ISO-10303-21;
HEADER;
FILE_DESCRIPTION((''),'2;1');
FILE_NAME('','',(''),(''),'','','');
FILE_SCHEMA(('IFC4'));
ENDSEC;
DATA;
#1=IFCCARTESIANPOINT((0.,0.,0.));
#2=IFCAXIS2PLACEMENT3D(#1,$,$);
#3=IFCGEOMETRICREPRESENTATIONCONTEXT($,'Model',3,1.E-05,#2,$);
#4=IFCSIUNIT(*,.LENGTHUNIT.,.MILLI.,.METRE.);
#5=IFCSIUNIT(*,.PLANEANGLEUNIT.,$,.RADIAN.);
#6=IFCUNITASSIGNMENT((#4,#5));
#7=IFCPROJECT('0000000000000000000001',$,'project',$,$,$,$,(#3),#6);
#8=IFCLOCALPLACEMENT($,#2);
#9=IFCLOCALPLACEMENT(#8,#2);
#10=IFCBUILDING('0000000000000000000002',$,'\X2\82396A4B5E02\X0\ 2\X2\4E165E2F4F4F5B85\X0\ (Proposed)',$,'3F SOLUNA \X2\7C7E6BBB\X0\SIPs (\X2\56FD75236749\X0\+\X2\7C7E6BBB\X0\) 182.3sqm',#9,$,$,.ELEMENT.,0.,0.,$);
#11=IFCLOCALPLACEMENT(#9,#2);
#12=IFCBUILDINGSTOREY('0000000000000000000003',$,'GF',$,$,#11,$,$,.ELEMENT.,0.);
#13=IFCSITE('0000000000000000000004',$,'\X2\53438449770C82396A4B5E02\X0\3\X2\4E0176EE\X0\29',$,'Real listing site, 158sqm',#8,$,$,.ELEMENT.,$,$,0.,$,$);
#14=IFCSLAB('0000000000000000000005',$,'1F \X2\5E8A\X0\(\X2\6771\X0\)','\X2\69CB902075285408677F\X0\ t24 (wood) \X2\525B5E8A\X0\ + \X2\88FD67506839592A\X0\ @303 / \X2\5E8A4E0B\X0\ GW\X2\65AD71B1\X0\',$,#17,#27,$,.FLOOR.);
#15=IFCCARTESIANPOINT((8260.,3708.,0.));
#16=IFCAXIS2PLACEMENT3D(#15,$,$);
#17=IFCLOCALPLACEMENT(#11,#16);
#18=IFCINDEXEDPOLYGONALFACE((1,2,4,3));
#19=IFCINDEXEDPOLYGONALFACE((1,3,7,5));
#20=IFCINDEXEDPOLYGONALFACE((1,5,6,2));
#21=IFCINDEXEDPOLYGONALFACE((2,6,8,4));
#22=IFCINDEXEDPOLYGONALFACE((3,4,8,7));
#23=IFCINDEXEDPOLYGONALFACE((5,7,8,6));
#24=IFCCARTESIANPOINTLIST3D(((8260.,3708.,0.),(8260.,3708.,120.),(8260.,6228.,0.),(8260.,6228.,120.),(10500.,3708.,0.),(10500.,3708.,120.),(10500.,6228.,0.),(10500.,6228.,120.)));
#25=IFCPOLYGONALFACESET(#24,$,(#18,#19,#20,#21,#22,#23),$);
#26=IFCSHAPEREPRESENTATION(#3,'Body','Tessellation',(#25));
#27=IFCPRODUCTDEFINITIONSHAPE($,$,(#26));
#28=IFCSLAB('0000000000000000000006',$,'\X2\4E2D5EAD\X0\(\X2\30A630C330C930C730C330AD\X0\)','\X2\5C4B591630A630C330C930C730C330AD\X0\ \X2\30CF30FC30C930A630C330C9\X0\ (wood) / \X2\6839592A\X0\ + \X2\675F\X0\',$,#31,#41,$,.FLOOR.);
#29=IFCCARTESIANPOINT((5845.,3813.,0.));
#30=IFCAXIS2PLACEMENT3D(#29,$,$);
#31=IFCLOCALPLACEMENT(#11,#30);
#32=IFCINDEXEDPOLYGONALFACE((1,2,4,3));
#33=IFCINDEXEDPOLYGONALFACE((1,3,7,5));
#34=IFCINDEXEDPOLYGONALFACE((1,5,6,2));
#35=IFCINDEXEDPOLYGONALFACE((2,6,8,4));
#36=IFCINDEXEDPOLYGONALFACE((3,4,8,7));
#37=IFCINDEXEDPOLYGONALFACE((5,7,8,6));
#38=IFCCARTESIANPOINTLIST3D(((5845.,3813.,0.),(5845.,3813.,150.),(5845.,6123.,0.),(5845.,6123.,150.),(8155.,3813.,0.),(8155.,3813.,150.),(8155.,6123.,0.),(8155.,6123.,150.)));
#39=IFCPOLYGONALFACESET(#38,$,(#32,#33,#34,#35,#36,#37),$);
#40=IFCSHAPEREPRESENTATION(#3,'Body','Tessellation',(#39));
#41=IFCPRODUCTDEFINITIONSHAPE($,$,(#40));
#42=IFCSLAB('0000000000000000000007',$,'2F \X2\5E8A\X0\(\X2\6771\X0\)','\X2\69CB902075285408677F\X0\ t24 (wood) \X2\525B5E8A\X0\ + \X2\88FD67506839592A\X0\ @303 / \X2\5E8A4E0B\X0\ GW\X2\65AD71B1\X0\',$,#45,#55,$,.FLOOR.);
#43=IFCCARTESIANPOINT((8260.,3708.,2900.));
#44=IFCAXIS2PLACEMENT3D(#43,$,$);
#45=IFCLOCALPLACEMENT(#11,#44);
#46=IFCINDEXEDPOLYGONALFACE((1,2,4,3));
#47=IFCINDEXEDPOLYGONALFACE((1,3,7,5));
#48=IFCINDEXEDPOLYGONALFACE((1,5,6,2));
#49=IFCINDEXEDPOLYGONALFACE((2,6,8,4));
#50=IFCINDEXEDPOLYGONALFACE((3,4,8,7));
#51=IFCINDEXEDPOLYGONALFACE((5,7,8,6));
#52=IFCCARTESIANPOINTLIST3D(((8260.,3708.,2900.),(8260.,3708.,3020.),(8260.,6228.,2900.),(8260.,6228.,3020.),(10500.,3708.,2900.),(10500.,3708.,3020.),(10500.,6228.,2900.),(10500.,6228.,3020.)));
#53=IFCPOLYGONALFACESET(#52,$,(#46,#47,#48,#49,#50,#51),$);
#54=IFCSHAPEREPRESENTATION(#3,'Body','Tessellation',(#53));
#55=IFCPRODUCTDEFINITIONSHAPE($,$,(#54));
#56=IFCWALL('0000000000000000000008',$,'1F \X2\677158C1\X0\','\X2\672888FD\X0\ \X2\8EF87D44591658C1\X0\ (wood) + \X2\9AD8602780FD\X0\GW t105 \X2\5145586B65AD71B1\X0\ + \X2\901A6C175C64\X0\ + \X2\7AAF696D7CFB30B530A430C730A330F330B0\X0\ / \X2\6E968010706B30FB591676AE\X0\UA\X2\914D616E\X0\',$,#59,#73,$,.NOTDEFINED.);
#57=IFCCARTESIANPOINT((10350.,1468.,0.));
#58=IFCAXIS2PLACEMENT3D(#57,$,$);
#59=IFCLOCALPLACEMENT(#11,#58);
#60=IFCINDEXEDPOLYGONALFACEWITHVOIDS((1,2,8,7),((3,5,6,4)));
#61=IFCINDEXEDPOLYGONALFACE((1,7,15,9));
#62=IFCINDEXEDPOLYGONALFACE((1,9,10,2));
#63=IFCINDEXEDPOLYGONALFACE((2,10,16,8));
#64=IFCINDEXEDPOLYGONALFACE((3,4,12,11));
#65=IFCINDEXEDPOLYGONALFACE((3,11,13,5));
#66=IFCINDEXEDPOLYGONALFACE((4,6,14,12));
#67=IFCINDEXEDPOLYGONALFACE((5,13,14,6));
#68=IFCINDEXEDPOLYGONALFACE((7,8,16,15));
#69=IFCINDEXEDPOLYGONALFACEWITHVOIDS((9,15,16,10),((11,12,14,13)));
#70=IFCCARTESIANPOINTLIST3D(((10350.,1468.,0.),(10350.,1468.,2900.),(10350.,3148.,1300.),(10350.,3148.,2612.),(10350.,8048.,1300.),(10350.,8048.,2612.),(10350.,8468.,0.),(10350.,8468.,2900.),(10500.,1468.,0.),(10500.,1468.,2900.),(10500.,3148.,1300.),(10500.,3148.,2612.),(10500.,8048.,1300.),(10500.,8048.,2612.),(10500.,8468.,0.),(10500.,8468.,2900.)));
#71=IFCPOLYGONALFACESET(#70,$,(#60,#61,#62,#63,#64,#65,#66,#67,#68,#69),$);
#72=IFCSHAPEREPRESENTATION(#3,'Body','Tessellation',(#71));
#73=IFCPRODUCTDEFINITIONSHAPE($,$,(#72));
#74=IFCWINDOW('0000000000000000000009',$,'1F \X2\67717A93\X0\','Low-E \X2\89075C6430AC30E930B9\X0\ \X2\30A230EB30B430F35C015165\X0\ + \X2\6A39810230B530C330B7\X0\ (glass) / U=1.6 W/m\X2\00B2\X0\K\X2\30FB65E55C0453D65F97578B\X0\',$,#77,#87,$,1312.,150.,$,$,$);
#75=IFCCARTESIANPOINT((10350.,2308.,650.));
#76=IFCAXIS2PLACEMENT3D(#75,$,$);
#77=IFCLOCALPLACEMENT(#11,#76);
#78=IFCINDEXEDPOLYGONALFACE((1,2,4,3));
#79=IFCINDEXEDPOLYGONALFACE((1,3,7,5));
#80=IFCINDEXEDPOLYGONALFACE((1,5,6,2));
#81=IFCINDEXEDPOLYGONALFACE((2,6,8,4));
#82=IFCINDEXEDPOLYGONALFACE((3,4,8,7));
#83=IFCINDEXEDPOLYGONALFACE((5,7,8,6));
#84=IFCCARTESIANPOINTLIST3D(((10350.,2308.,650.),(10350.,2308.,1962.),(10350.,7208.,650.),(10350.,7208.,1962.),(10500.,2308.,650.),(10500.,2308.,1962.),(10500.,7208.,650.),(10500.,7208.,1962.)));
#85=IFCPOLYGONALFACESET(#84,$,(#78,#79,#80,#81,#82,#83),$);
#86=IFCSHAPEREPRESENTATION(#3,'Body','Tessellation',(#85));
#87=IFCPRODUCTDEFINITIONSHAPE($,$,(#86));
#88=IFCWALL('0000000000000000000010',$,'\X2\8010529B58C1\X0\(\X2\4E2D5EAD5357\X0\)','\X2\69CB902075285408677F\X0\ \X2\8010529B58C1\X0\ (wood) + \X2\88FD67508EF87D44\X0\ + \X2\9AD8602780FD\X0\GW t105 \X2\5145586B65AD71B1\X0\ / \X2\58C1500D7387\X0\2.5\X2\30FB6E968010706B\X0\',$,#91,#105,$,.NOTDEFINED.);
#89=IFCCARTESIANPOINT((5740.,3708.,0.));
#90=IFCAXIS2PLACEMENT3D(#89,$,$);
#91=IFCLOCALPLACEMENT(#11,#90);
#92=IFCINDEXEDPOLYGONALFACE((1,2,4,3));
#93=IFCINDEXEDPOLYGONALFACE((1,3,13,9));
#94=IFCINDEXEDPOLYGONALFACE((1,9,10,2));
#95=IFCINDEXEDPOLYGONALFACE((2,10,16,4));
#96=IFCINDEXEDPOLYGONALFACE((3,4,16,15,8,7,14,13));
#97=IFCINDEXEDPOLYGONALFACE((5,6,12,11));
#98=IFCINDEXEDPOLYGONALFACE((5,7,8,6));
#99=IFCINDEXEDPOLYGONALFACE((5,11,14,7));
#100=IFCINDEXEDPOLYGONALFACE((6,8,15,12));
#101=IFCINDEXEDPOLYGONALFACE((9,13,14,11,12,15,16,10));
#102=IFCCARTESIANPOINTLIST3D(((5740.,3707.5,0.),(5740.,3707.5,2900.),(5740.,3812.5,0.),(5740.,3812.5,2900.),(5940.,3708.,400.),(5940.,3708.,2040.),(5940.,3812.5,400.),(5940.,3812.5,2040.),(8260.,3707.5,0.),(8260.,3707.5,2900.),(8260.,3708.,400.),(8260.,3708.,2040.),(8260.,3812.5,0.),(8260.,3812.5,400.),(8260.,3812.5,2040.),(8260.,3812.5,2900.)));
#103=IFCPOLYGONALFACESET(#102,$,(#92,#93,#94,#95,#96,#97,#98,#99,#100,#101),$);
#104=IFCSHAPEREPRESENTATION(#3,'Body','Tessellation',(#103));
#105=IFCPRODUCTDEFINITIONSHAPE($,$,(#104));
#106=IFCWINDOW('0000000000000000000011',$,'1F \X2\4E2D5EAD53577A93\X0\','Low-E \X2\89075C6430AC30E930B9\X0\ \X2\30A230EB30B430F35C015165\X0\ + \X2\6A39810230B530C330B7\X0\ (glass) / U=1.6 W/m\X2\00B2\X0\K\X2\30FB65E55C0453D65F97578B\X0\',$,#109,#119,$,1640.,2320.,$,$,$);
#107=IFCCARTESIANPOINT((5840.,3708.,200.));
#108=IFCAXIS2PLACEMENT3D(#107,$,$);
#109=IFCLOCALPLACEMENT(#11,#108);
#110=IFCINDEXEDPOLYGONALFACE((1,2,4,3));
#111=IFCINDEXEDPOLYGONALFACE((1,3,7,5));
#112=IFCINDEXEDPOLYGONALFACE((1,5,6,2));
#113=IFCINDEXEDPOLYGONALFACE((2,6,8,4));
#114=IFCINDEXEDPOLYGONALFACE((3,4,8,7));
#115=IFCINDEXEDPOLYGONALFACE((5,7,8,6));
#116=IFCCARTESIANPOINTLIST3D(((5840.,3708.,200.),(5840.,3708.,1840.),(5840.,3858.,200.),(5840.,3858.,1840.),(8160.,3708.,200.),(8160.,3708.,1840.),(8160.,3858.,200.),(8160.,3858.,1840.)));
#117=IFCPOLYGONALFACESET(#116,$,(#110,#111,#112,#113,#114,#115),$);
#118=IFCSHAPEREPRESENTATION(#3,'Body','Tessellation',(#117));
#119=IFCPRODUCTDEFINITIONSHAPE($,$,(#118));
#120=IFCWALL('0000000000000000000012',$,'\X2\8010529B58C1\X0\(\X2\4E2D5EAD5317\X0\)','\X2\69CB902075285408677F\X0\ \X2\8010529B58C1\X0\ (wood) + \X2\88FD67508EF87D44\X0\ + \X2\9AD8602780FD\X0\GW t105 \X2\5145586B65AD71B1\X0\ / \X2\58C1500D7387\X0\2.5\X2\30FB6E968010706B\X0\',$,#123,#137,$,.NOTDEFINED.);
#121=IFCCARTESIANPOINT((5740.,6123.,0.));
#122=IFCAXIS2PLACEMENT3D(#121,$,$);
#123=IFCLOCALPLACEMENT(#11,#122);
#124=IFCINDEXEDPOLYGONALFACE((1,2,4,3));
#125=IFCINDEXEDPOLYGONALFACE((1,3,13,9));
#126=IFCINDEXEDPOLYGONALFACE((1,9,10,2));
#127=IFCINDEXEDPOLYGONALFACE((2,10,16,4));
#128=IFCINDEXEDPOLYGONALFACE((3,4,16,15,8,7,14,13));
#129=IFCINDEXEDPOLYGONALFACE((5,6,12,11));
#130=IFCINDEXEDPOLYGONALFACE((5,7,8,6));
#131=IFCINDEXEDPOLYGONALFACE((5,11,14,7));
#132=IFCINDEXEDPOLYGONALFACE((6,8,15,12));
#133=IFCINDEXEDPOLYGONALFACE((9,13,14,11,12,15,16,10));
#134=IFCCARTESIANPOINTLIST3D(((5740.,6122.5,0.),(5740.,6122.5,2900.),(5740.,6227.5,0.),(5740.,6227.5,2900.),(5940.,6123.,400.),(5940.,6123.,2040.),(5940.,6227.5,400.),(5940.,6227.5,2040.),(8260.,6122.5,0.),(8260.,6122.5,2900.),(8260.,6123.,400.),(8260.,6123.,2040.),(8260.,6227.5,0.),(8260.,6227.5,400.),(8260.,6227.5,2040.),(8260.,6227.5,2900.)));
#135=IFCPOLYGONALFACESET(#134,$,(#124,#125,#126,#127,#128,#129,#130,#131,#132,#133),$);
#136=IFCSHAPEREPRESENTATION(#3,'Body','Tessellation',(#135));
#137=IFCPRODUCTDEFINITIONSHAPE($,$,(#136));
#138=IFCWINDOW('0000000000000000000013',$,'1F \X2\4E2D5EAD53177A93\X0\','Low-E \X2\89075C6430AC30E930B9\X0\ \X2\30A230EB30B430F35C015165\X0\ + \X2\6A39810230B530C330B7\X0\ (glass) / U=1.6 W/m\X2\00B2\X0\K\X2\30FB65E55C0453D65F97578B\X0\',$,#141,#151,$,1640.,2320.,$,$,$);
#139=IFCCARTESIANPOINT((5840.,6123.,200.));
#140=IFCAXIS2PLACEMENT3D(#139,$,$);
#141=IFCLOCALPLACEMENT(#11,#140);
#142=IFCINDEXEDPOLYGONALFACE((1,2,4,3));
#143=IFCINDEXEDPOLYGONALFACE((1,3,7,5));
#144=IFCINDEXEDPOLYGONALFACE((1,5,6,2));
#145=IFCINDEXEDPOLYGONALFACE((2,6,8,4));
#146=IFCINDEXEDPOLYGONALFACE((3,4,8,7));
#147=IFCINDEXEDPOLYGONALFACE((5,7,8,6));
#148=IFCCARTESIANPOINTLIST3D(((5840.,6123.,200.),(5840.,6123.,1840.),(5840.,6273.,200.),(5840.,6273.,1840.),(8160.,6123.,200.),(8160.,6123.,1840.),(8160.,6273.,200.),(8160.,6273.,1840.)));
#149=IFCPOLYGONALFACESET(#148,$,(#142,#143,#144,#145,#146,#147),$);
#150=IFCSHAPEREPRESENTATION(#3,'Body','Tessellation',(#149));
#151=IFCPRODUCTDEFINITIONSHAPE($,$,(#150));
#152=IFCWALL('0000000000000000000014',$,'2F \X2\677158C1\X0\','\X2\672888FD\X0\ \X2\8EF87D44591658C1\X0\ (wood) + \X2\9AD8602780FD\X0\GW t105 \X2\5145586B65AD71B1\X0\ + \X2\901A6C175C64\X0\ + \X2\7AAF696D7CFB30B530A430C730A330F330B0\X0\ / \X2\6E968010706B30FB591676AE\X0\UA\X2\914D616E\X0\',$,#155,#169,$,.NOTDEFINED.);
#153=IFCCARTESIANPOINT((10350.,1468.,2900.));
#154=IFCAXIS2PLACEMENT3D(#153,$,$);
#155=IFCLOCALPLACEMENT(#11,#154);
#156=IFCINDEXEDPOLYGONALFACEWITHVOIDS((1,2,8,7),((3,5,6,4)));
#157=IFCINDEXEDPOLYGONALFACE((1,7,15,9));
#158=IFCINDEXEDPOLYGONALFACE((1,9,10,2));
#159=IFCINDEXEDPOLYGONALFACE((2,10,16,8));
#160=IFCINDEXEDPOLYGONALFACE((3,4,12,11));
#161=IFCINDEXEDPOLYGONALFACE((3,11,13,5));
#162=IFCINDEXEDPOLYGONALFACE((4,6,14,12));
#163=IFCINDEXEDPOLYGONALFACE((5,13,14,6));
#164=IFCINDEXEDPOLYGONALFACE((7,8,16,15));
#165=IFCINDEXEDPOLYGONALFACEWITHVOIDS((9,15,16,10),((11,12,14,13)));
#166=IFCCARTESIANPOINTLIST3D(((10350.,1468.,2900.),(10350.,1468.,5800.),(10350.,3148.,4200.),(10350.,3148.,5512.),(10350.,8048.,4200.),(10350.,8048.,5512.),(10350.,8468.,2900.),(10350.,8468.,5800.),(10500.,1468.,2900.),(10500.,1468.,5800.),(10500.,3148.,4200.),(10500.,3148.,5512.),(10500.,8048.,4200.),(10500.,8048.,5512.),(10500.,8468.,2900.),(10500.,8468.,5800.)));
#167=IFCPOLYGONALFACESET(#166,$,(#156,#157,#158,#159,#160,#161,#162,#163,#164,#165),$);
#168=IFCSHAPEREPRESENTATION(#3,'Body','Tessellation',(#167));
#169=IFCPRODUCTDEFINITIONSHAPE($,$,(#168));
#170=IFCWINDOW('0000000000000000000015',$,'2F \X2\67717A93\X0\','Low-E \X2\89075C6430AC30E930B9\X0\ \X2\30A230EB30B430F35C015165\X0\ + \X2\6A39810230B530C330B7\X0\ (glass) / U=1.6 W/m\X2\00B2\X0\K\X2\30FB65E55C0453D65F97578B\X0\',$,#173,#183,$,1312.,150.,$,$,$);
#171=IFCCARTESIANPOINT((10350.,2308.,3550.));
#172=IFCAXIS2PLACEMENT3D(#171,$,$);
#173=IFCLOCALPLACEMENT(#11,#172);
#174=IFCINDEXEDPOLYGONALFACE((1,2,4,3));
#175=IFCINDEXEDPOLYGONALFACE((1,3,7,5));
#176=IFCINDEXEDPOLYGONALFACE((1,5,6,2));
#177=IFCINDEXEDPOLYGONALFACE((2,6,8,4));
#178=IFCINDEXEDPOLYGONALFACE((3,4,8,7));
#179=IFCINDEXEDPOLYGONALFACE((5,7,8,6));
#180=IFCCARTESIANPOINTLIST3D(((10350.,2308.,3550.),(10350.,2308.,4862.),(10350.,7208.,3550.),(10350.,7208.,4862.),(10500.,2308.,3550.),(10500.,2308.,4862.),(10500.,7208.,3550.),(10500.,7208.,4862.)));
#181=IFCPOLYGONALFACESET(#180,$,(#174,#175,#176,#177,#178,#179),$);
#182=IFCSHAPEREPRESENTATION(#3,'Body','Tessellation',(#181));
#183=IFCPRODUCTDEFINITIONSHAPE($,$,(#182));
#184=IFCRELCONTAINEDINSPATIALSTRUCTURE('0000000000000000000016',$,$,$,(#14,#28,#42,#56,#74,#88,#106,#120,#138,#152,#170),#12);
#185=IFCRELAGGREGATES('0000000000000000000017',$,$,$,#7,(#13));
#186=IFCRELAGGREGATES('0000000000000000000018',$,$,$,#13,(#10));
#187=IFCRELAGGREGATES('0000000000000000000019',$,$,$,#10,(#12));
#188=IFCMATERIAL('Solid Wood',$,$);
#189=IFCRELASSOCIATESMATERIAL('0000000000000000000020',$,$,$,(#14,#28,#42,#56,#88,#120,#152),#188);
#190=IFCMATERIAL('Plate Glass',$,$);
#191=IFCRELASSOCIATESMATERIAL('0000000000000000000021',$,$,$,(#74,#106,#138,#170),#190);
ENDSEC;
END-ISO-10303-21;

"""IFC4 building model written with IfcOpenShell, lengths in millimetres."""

from ifc_helpers import new_model, si_unit, frame, frame_2d, origin, place, context, project, spatial, rectangle, extrude, material, element, fill, save


model = new_model("IFC4")

# Units and contexts
model_context = context("Model", 3, precision=1e-05, world=origin())
ifc_project = project(units=[si_unit("LENGTHUNIT", "METRE", prefix="MILLI"), si_unit("PLANEANGLEUNIT", "RADIAN")], contexts=[model_context])

# Site, building, storey
site_placement = place(None, origin())
site = spatial("IfcSite", under=ifc_project, at=site_placement, Name="千葉県船橋市3丁目29", ObjectType="Real listing site, 158sqm", CompositionType="ELEMENT", RefElevation=0.0)
building_placement = place(site_placement, origin())
building = spatial("IfcBuilding", under=site, at=building_placement, Name="船橋市 2世帯住宅 (Proposed)", ObjectType="3F SOLUNA 籾殻SIPs (国産杉+籾殻) 182.3sqm", CompositionType="ELEMENT", ElevationOfRefHeight=0.0, ElevationOfTerrain=0.0)
storey_placement = place(building_placement, origin())
storey = spatial("IfcBuildingStorey", under=building, at=storey_placement, Name="GF", CompositionType="ELEMENT", Elevation=0.0)

# Slabs
ifc_material_1 = material(Name="Solid Wood")
slab_1_placement = place(storey_placement, frame((8260.0, 3708.0, 0.0)))
element("IfcSlab", 1, at=slab_1_placement, inside=storey, material=ifc_material_1, Name="1F 床(東)", Description="構造用合板 t24 (wood) 剛床 + 製材根太 @303 / 床下 GW断熱", PredefinedType="FLOOR", context=model_context, shape_type="SweptSolid", body=[
    extrude(rectangle(XDim=2240.0, YDim=2520.0, at=frame_2d((1120.0, 1260.0))), frame((8260.0, 3708.0, 0.0)), (0.0, 0.0, 1.0), 120.0),
])
slab_2_placement = place(storey_placement, frame((5845.0, 3813.0, 0.0)))
element("IfcSlab", 2, at=slab_2_placement, inside=storey, material=ifc_material_1, Name="中庭(ウッドデッキ)", Description="屋外ウッドデッキ ハードウッド (wood) / 根太 + 束", PredefinedType="FLOOR", context=model_context, shape_type="SweptSolid", body=[
    extrude(rectangle(XDim=2310.0, YDim=2310.0, at=frame_2d((1155.0, 1155.0))), frame((5845.0, 3813.0, 0.0)), (0.0, 0.0, 1.0), 150.0),
])
slab_3_placement = place(storey_placement, frame((8260.0, 3708.0, 2900.0)))
element("IfcSlab", 3, at=slab_3_placement, inside=storey, material=ifc_material_1, Name="2F 床(東)", Description="構造用合板 t24 (wood) 剛床 + 製材根太 @303 / 床下 GW断熱", PredefinedType="FLOOR", context=model_context, shape_type="SweptSolid", body=[
    extrude(rectangle(XDim=2240.0, YDim=2520.0, at=frame_2d((1120.0, 1260.0))), frame((8260.0, 3708.0, 2900.0)), (0.0, 0.0, 1.0), 120.0),
])

# Walls, openings, windows
wall_1_placement = place(storey_placement, frame((10350.0, 1468.0, 0.0)))
wall_1 = element("IfcWall", 4, at=wall_1_placement, inside=storey, material=ifc_material_1, Name="1F 東壁", Description="木製 軸組外壁 (wood) + 高性能GW t105 充填断熱 + 通気層 + 窯業系サイディング / 準耐火・外皮UA配慮", PredefinedType="NOTDEFINED", context=model_context, shape_type="SweptSolid", body=[
    extrude(rectangle(XDim=150.0, YDim=7000.0, at=frame_2d((75.0, 3500.0))), frame((10350.0, 1468.0, 0.0)), (0.0, 0.0, 1.0), 2900.0),
])
opening_1_placement = place(storey_placement, frame((10350.0, 2308.0, 650.0)))
opening_1 = element("IfcOpeningElement", 5, at=opening_1_placement, cuts=wall_1, PredefinedType="NOTDEFINED", context=model_context, shape_type="SweptSolid", body=[
    extrude(rectangle(XDim=150.0, YDim=4900.0, at=frame_2d((75.0, 2450.0))), frame((10350.0, 2308.0, 650.0)), (0.0, 0.0, 1.0), 1312.0),
])
ifc_material_2 = material(Name="Plate Glass")
window_1_placement = place(storey_placement, frame((10350.0, 2308.0, 650.0)))
window_1 = element("IfcWindow", 6, at=window_1_placement, inside=storey, material=ifc_material_2, Name="1F 東窓", Description="Low-E 複層ガラス アルゴン封入 + 樹脂サッシ (glass) / U=1.6 W/m²K・日射取得型", OverallHeight=1312.0, OverallWidth=150.0, context=model_context, shape_type="SweptSolid", body=[
    extrude(rectangle(XDim=150.0, YDim=4900.0, at=frame_2d((75.0, 2450.0))), frame((10350.0, 2308.0, 650.0)), (0.0, 0.0, 1.0), 1312.0),
])
fill(opening_1, window_1)
wall_2_placement = place(storey_placement, frame((5740.0, 3708.0, 0.0)))
wall_2 = element("IfcWall", 7, at=wall_2_placement, inside=storey, material=ifc_material_1, Name="耐力壁(中庭南)", Description="構造用合板 耐力壁 (wood) + 製材軸組 + 高性能GW t105 充填断熱 / 壁倍率2.5・準耐火", PredefinedType="NOTDEFINED", context=model_context, shape_type="SweptSolid", body=[
    extrude(rectangle(XDim=2520.0, YDim=105.0, at=frame_2d((1260.0, 52.0))), frame((5740.0, 3708.0, 0.0)), (0.0, 0.0, 1.0), 2900.0),
])
opening_2_placement = place(storey_placement, frame((5840.0, 3708.0, 200.0)))
opening_2 = element("IfcOpeningElement", 8, at=opening_2_placement, cuts=wall_2, PredefinedType="NOTDEFINED", context=model_context, shape_type="SweptSolid", body=[
    extrude(rectangle(XDim=2320.0, YDim=150.0, at=frame_2d((1160.0, 75.0))), frame((5840.0, 3708.0, 200.0)), (0.0, 0.0, 1.0), 1640.0),
])
window_2_placement = place(storey_placement, frame((5840.0, 3708.0, 200.0)))
window_2 = element("IfcWindow", 9, at=window_2_placement, inside=storey, material=ifc_material_2, Name="1F 中庭南窓", Description="Low-E 複層ガラス アルゴン封入 + 樹脂サッシ (glass) / U=1.6 W/m²K・日射取得型", OverallHeight=1640.0, OverallWidth=2320.0, context=model_context, shape_type="SweptSolid", body=[
    extrude(rectangle(XDim=2320.0, YDim=150.0, at=frame_2d((1160.0, 75.0))), frame((5840.0, 3708.0, 200.0)), (0.0, 0.0, 1.0), 1640.0),
])
fill(opening_2, window_2)
wall_3_placement = place(storey_placement, frame((5740.0, 6123.0, 0.0)))
wall_3 = element("IfcWall", 10, at=wall_3_placement, inside=storey, material=ifc_material_1, Name="耐力壁(中庭北)", Description="構造用合板 耐力壁 (wood) + 製材軸組 + 高性能GW t105 充填断熱 / 壁倍率2.5・準耐火", PredefinedType="NOTDEFINED", context=model_context, shape_type="SweptSolid", body=[
    extrude(rectangle(XDim=2520.0, YDim=105.0, at=frame_2d((1260.0, 52.0))), frame((5740.0, 6123.0, 0.0)), (0.0, 0.0, 1.0), 2900.0),
])
opening_3_placement = place(storey_placement, frame((5840.0, 6123.0, 200.0)))
opening_3 = element("IfcOpeningElement", 11, at=opening_3_placement, cuts=wall_3, PredefinedType="NOTDEFINED", context=model_context, shape_type="SweptSolid", body=[
    extrude(rectangle(XDim=2320.0, YDim=150.0, at=frame_2d((1160.0, 75.0))), frame((5840.0, 6123.0, 200.0)), (0.0, 0.0, 1.0), 1640.0),
])
window_3_placement = place(storey_placement, frame((5840.0, 6123.0, 200.0)))
window_3 = element("IfcWindow", 12, at=window_3_placement, inside=storey, material=ifc_material_2, Name="1F 中庭北窓", Description="Low-E 複層ガラス アルゴン封入 + 樹脂サッシ (glass) / U=1.6 W/m²K・日射取得型", OverallHeight=1640.0, OverallWidth=2320.0, context=model_context, shape_type="SweptSolid", body=[
    extrude(rectangle(XDim=2320.0, YDim=150.0, at=frame_2d((1160.0, 75.0))), frame((5840.0, 6123.0, 200.0)), (0.0, 0.0, 1.0), 1640.0),
])
fill(opening_3, window_3)

# Wall, opening, window
wall_4_placement = place(storey_placement, frame((10350.0, 1468.0, 2900.0)))
wall_4 = element("IfcWall", 13, at=wall_4_placement, inside=storey, material=ifc_material_1, Name="2F 東壁", Description="木製 軸組外壁 (wood) + 高性能GW t105 充填断熱 + 通気層 + 窯業系サイディング / 準耐火・外皮UA配慮", PredefinedType="NOTDEFINED", context=model_context, shape_type="SweptSolid", body=[
    extrude(rectangle(XDim=150.0, YDim=7000.0, at=frame_2d((75.0, 3500.0))), frame((10350.0, 1468.0, 2900.0)), (0.0, 0.0, 1.0), 2900.0),
])
opening_4_placement = place(storey_placement, frame((10350.0, 2308.0, 3550.0)))
opening_4 = element("IfcOpeningElement", 14, at=opening_4_placement, cuts=wall_4, PredefinedType="NOTDEFINED", context=model_context, shape_type="SweptSolid", body=[
    extrude(rectangle(XDim=150.0, YDim=4900.0, at=frame_2d((75.0, 2450.0))), frame((10350.0, 2308.0, 3550.0)), (0.0, 0.0, 1.0), 1312.0),
])
window_4_placement = place(storey_placement, frame((10350.0, 2308.0, 3550.0)))
window_4 = element("IfcWindow", 15, at=window_4_placement, inside=storey, material=ifc_material_2, Name="2F 東窓", Description="Low-E 複層ガラス アルゴン封入 + 樹脂サッシ (glass) / U=1.6 W/m²K・日射取得型", OverallHeight=1312.0, OverallWidth=150.0, context=model_context, shape_type="SweptSolid", body=[
    extrude(rectangle(XDim=150.0, YDim=4900.0, at=frame_2d((75.0, 2450.0))), frame((10350.0, 2308.0, 3550.0)), (0.0, 0.0, 1.0), 1312.0),
])
fill(opening_4, window_4)

save(model, "model.ifc")
